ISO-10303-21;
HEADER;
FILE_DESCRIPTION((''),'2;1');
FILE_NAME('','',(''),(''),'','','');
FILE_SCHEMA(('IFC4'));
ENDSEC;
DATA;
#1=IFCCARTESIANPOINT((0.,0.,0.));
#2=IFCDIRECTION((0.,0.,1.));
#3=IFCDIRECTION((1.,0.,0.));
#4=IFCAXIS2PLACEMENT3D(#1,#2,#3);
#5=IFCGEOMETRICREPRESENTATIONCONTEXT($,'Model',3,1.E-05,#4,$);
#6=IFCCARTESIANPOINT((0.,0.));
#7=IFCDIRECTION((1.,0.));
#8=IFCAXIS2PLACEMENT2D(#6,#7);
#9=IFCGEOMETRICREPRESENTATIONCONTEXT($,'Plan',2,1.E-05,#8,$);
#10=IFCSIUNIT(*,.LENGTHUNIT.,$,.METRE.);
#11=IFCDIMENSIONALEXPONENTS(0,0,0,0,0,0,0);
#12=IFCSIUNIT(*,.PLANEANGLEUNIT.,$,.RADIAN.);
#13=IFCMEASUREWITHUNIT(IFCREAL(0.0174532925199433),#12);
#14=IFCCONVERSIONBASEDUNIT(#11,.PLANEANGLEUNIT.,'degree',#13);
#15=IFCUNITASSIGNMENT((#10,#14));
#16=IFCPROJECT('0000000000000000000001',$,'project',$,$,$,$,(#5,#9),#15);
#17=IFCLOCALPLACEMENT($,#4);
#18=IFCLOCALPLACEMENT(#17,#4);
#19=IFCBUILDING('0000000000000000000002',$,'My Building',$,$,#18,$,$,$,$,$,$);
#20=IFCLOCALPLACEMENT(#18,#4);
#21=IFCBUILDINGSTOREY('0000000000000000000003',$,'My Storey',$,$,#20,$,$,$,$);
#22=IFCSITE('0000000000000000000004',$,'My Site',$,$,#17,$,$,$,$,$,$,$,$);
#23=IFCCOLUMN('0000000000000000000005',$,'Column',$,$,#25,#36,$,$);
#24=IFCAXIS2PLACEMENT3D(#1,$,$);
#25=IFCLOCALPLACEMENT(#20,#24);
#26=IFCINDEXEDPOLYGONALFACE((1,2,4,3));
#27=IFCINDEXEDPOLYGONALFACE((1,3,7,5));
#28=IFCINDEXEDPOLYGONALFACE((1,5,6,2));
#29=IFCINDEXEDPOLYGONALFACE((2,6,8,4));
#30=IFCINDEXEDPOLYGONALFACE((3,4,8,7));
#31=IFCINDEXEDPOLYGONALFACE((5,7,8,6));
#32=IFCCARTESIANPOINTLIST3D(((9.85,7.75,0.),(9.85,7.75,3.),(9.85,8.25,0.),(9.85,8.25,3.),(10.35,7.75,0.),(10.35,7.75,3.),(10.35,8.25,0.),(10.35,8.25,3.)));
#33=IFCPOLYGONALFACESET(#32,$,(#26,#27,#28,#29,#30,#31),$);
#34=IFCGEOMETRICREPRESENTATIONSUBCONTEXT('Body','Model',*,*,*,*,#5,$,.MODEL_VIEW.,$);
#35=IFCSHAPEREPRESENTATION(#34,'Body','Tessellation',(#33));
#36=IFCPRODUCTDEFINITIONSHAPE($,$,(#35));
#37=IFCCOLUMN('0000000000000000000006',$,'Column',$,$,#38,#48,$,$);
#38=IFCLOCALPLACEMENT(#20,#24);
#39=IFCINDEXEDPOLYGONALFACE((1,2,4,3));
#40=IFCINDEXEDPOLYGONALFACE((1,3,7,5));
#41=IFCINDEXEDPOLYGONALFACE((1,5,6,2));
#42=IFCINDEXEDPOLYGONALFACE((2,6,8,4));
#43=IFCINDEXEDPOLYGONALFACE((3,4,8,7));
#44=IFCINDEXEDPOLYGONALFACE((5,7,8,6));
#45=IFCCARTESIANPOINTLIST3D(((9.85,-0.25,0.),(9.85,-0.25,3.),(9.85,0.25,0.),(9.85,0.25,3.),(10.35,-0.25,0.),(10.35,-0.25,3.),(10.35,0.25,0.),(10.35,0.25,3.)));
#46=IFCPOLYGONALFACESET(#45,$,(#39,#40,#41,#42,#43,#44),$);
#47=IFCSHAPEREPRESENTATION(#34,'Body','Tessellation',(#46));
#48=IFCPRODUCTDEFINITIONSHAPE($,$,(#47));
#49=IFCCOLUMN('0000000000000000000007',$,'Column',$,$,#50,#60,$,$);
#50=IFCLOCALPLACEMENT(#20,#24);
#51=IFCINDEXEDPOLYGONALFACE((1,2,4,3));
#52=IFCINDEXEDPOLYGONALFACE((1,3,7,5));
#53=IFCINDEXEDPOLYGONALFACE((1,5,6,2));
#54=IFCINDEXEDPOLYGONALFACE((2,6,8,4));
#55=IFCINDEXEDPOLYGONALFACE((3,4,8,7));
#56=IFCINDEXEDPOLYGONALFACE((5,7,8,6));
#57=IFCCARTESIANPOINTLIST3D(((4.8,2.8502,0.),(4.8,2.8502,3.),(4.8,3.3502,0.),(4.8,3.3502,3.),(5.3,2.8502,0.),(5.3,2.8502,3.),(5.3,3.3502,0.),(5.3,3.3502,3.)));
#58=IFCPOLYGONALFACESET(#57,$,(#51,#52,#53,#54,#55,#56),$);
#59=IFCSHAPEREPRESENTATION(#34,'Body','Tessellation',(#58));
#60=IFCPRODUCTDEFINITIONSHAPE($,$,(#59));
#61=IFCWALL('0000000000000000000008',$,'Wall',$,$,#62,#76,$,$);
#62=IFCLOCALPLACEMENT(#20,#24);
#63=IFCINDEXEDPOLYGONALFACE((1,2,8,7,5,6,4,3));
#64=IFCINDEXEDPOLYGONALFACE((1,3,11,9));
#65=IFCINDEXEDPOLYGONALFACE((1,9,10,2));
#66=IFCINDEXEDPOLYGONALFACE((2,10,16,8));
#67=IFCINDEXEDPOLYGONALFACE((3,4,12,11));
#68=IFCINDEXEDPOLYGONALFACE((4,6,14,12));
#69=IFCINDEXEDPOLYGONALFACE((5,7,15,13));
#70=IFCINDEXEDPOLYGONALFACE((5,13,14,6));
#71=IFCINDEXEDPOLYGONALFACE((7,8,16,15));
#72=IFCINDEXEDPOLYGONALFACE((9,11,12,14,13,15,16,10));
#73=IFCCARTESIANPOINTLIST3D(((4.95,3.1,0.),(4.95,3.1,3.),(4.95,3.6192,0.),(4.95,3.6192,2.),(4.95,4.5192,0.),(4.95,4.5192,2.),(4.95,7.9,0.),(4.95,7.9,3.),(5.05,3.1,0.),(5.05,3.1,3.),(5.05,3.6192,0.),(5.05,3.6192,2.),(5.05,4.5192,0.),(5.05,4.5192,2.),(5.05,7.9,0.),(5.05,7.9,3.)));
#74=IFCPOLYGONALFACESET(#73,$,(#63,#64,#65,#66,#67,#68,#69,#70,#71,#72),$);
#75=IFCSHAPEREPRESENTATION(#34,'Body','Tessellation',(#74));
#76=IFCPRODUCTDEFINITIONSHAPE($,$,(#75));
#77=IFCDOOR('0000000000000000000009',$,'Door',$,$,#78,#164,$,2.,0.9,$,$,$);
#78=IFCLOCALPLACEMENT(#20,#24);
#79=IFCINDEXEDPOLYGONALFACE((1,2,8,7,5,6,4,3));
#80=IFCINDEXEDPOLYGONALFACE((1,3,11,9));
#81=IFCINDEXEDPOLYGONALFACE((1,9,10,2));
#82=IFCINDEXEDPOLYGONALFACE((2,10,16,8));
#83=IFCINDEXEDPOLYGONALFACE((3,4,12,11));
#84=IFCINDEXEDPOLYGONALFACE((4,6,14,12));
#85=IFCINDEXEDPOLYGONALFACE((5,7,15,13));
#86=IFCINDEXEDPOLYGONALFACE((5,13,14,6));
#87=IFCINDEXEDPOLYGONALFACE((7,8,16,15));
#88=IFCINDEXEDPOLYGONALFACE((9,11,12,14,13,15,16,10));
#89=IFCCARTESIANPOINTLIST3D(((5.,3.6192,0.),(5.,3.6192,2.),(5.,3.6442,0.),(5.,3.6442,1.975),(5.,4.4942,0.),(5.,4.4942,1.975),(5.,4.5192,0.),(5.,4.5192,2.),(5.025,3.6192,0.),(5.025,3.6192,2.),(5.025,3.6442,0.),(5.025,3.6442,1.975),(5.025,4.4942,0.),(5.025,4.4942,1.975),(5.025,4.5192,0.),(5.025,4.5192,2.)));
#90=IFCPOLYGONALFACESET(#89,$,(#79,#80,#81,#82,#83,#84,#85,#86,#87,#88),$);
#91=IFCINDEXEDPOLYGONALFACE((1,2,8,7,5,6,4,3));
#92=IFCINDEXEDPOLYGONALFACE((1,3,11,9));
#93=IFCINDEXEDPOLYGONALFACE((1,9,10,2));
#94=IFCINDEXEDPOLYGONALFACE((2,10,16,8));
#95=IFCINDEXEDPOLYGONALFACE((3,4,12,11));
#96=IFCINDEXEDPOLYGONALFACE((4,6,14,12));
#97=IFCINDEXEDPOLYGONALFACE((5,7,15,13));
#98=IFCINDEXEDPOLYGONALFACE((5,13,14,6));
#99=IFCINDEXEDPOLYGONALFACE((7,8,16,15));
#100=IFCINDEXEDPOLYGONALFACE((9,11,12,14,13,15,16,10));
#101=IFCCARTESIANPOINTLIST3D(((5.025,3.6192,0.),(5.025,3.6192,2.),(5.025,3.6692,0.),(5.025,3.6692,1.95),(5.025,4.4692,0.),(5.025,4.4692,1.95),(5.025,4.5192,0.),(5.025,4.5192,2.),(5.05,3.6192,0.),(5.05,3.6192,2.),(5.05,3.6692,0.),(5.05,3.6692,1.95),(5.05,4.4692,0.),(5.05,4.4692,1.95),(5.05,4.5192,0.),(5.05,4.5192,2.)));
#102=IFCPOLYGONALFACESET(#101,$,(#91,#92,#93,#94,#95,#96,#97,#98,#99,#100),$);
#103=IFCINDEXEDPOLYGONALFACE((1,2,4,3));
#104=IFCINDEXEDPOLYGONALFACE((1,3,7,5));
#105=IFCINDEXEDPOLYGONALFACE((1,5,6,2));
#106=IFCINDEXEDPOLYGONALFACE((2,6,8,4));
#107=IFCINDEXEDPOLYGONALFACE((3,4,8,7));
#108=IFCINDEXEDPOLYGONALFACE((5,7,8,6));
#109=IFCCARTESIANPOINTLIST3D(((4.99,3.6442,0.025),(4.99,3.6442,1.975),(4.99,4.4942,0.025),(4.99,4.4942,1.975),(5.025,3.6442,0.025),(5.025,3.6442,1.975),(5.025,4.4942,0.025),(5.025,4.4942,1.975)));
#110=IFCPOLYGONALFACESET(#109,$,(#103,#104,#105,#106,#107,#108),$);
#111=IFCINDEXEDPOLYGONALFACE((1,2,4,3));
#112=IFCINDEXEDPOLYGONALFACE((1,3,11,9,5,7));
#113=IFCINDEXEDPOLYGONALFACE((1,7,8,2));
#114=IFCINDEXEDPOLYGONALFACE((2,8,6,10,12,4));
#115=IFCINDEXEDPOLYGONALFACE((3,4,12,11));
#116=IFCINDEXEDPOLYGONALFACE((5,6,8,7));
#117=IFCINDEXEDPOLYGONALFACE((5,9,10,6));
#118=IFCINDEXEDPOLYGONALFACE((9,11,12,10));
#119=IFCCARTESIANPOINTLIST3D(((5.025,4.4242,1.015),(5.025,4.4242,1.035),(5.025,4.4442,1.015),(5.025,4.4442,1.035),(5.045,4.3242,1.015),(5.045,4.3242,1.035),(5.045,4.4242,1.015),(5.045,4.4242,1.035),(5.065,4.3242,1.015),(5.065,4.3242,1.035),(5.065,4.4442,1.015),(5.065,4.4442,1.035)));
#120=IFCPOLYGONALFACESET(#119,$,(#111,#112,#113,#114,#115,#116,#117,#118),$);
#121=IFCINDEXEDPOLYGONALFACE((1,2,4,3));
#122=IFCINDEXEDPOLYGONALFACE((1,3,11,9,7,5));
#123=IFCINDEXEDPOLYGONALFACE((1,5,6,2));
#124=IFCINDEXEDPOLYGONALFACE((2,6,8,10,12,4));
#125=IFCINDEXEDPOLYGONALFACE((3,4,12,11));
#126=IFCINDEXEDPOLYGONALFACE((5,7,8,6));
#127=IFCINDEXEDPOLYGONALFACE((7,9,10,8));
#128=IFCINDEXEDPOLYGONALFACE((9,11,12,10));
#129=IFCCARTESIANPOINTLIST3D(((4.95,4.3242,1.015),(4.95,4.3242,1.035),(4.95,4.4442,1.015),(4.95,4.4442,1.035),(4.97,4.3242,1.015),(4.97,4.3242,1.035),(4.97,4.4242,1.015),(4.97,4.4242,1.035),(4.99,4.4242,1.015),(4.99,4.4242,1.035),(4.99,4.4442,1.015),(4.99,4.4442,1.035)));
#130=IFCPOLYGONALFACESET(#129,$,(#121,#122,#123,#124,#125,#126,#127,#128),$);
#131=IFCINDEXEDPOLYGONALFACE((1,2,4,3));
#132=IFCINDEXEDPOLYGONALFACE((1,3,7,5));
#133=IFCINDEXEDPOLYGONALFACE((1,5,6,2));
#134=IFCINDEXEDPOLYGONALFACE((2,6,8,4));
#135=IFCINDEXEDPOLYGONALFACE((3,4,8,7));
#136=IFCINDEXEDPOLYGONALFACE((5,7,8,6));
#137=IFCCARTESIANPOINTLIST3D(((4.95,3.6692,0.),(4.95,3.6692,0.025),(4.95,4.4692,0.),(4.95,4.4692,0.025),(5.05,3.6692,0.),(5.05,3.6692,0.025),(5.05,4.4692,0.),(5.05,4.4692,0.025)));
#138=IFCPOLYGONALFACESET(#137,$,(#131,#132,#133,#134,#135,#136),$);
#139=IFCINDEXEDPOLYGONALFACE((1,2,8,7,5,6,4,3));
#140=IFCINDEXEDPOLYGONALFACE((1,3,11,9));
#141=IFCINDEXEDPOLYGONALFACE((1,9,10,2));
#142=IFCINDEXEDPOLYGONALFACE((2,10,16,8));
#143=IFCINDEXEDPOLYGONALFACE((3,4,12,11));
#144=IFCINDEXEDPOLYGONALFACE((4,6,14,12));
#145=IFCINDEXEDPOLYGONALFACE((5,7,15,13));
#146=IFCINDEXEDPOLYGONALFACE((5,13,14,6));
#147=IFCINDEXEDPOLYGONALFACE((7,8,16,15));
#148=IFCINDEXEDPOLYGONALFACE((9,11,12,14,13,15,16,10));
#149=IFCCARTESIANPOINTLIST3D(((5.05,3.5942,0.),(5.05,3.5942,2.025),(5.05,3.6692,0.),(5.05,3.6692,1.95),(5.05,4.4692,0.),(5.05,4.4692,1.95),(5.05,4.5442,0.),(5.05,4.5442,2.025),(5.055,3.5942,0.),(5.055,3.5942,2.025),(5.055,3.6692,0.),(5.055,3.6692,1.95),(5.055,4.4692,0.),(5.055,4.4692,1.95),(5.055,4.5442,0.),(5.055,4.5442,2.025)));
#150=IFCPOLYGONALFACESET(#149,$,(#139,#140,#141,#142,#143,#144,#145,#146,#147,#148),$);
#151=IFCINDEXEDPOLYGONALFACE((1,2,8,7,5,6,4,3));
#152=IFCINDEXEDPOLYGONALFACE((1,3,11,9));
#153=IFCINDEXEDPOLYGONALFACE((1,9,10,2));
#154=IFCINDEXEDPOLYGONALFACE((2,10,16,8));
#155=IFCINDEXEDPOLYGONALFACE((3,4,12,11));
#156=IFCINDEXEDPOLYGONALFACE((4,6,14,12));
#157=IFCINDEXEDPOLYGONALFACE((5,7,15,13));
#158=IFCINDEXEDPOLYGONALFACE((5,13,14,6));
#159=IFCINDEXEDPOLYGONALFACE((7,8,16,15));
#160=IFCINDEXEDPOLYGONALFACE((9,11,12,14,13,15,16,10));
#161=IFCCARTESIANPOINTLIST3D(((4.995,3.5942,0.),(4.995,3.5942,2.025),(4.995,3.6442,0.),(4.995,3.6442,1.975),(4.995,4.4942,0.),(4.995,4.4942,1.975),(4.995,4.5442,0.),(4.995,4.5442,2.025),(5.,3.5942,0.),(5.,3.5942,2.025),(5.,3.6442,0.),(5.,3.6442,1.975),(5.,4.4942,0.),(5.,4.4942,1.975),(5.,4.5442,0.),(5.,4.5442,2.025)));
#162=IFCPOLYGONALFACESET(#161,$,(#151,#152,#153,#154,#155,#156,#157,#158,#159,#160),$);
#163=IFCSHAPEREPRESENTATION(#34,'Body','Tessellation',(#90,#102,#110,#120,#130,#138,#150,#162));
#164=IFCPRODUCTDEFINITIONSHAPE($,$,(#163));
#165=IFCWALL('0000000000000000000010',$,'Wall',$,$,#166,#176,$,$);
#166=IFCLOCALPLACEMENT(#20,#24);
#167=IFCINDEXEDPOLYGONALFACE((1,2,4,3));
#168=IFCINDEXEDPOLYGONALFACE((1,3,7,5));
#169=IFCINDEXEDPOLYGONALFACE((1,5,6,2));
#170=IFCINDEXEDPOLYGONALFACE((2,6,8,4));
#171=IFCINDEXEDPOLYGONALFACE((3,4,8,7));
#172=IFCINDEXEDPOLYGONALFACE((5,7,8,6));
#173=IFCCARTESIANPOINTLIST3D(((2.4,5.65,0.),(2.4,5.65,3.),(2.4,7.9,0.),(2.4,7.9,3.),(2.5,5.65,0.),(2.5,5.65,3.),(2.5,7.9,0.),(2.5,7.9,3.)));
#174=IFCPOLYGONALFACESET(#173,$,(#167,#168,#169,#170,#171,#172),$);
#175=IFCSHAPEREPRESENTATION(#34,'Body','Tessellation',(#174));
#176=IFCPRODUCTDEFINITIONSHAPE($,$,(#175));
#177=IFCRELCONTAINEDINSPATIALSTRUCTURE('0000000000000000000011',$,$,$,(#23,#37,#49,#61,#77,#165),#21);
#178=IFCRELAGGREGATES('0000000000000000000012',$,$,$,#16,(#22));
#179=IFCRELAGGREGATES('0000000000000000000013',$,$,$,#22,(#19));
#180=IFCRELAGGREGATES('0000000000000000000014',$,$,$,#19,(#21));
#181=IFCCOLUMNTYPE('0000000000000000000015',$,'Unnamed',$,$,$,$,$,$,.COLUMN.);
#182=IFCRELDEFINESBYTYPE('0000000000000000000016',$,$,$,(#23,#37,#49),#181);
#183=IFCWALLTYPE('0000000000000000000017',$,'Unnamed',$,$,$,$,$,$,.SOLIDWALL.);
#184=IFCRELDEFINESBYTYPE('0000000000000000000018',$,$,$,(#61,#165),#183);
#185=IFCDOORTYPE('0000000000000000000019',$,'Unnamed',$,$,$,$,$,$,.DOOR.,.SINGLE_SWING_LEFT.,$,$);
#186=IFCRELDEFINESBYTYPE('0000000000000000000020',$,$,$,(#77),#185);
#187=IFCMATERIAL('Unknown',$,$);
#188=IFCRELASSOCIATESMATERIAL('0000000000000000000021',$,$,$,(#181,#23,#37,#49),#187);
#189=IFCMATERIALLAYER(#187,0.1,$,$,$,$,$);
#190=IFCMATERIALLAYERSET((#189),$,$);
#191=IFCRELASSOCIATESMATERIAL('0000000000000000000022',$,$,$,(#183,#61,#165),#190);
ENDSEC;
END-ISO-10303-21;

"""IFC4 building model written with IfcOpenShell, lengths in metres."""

from ifc_helpers import new_model, entity, si_unit, converted_unit, frame, origin_with_axes, origin_2d_with_axis, place, context, subcontext, project, spatial, line, indexed_curve, rectangle, outline, extrude, shape, source, transform, mapped, material, layer, layer_set, layer_usage, material_profile, profile_set, profile_usage, type_object, type_shapes, element, fill, save


model = new_model("IFC4")

# Units and contexts
model_context = context("Model", 3, precision=1e-05, world=origin_with_axes())
plan_context = context("Plan", 2, precision=1e-05, world=origin_2d_with_axis())
body_context_1 = subcontext(model_context, "Body", "Model", "MODEL_VIEW")
body_context_2 = subcontext(plan_context, "Body", "Plan", "PLAN_VIEW")
ifc_project = project(units=[si_unit("LENGTHUNIT", "METRE"), converted_unit("PLANEANGLEUNIT", "degree", entity("IfcReal", 0.0174532925199433), si_unit("PLANEANGLEUNIT", "RADIAN"), dimensions=[0, 0, 0, 0, 0, 0, 0])], contexts=[model_context, plan_context])

# Site, building, storey
site_placement = place(None, origin_with_axes())
site = spatial("IfcSite", under=ifc_project, at=site_placement, Name="My Site")
building_placement = place(site_placement, origin_with_axes())
building = spatial("IfcBuilding", under=site, at=building_placement, Name="My Building")
storey_placement = place(building_placement, origin_with_axes())
storey = spatial("IfcBuildingStorey", under=building, at=storey_placement, Name="My Storey")

# Columns
ifc_material = material(Name="Unknown")
ifc_material_profile = material_profile(ifc_material, rectangle(XDim=0.5, YDim=0.5))
ifc_profile_set = profile_set([ifc_material_profile])
ifc_profile_usage_1 = profile_usage(ifc_profile_set, cardinal=5)
column_type = type_object("IfcColumnType", Name="Unnamed", PredefinedType="COLUMN", material=ifc_profile_set)
column_1_placement = place(storey_placement, frame((10.1, 8.0, 0.0), z_axis=(0.0, 0.0, 1.0), x_axis=(1.0, 0.0, 0.0)))
element("IfcColumn", 1, at=column_1_placement, inside=storey, type_object=column_type, material=ifc_profile_usage_1, Name="Column", context=body_context_1, shape_type="SweptSolid", body=[
    extrude(rectangle(XDim=0.5, YDim=0.5), origin_with_axes(), (0.0, 0.0, 1.0), 3.0),
])
ifc_profile_usage_2 = profile_usage(ifc_profile_set, cardinal=5)
column_2_placement = place(storey_placement, frame((10.1, 0.0, 0.0), z_axis=(0.0, 0.0, 1.0), x_axis=(1.0, 0.0, 0.0)))
element("IfcColumn", 2, at=column_2_placement, inside=storey, type_object=column_type, material=ifc_profile_usage_2, Name="Column", context=body_context_1, shape_type="SweptSolid", body=[
    extrude(rectangle(XDim=0.5, YDim=0.5), origin_with_axes(), (0.0, 0.0, 1.0), 3.0),
])
ifc_profile_usage_3 = profile_usage(ifc_profile_set, cardinal=5)
column_3_placement = place(storey_placement, frame((5.05, 3.1002, 0.0), z_axis=(0.0, 0.0, 1.0), x_axis=(1.0, 0.0, 0.0)))
element("IfcColumn", 3, at=column_3_placement, inside=storey, type_object=column_type, material=ifc_profile_usage_3, Name="Column", context=body_context_1, shape_type="SweptSolid", body=[
    extrude(rectangle(XDim=0.5, YDim=0.5), origin_with_axes(), (0.0, 0.0, 1.0), 3.0),
])

# Shared definitions
ifc_layer = layer(ifc_material, 0.1)
ifc_layer_set = layer_set([ifc_layer])
wall_type = type_object("IfcWallType", Name="Unnamed", PredefinedType="SOLIDWALL", material=ifc_layer_set)
shared_shape_1 = source(origin_with_axes(), body_context_1, "Body", "SweptSolid", [
    extrude(outline(indexed_curve([(0.0, 0.0), (0.9, 0.0), (0.9, 2.0), (0.0, 2.0)], segments=[line(1, 2, 3, 4, 1)])), frame((0.0, -0.6, 0.0), z_axis=(0.0, -1.0, 0.0), x_axis=(1.0, 0.0, 0.0)), (0.0, 0.0, -1.0), 1.2),
])
door_type = type_object("IfcDoorType", Name="Unnamed", OperationType="SINGLE_SWING_LEFT", PredefinedType="DOOR")
shared_shape_2 = source(origin_with_axes(), body_context_1, "Body", "SweptSolid", [
    extrude(outline(indexed_curve([(0.0, 0.0), (0.0, 2.0), (0.9, 2.0), (0.9, 0.0), (0.875, 0.0), (0.875, 1.975), (0.025, 1.975), (0.025, 0.0)], segments=[line(1, 2, 3, 4, 5, 6, 7, 8, 1)])), frame((0.0, 0.025, 0.0), z_axis=(0.0, -1.0, 0.0), x_axis=(1.0, 0.0, 0.0)), (0.0, 0.0, -1.0), 0.025),
    extrude(outline(indexed_curve([(0.0, 0.0), (0.0, 2.0), (0.9, 2.0), (0.9, 0.0), (0.85, 0.0), (0.85, 1.95), (0.05, 1.95), (0.05, 0.0)], segments=[line(1, 2, 3, 4, 5, 6, 7, 8, 1)])), frame((0.0, 0.0, 0.0), z_axis=(0.0, -1.0, 0.0), x_axis=(1.0, 0.0, 0.0)), (0.0, 0.0, -1.0), 0.025),
    extrude(outline(indexed_curve([(0.0, 0.0), (0.85, 0.0), (0.85, 0.035), (0.0, 0.035)], segments=[line(1, 2, 3, 4, 1)])), frame((0.025, 0.025, 0.025), z_axis=(0.0, 0.0, 1.0), x_axis=(1.0, 0.0, 0.0)), (0.0, 0.0, 1.0), 1.95),
    extrude(outline(indexed_curve([(0.0, 0.0), (0.0, -0.04), (-0.12, -0.04), (-0.12, -0.02), (-0.02, -0.02), (-0.02, 0.0)], segments=[line(1, 2, 3, 4, 5, 6, 1)])), frame((0.825, 0.025, 1.015), z_axis=(0.0, 0.0, 1.0), x_axis=(1.0, 0.0, 0.0)), (0.0, 0.0, 1.0), 0.02),
    extrude(outline(indexed_curve([(0.0, 0.0), (0.0, 0.04), (-0.12, 0.04), (-0.12, 0.02), (-0.02, 0.02), (-0.02, 0.0)], segments=[line(1, 2, 3, 4, 5, 6, 1)])), frame((0.825, 0.06, 1.015), z_axis=(0.0, 0.0, 1.0), x_axis=(1.0, 0.0, 0.0)), (0.0, 0.0, 1.0), 0.02),
    extrude(outline(indexed_curve([(0.0, 0.0), (0.8, 0.0), (0.8, 0.1), (0.0, 0.1)], segments=[line(1, 2, 3, 4, 1)])), frame((0.05, 0.0, 0.0), z_axis=(0.0, 0.0, 1.0), x_axis=(1.0, 0.0, 0.0)), (0.0, 0.0, 1.0), 0.025),
    extrude(outline(indexed_curve([(0.0, 0.0), (0.0, 2.025), (0.95, 2.025), (0.95, 0.0), (0.875, 0.0), (0.875, 1.95), (0.075, 1.95), (0.075, 0.0)], segments=[line(1, 2, 3, 4, 5, 6, 7, 8, 1)])), frame((-0.025, -0.005, 0.0), z_axis=(0.0, -1.0, 0.0), x_axis=(1.0, 0.0, 0.0)), (0.0, 0.0, -1.0), 0.005),
    extrude(outline(indexed_curve([(0.0, 0.0), (0.0, 2.025), (0.95, 2.025), (0.95, 0.0), (0.9, 0.0), (0.9, 1.975), (0.05, 1.975), (0.05, 0.0)], segments=[line(1, 2, 3, 4, 5, 6, 7, 8, 1)])), frame((-0.025, 0.05, 0.0), z_axis=(0.0, -1.0, 0.0), x_axis=(1.0, 0.0, 0.0)), (0.0, 0.0, -1.0), 0.005),
])
shared_shape_3 = source(origin_with_axes(), body_context_2, "Body", "Curve2D", [
    entity("IfcIndexedPolyCurve", entity("IfcCartesianPointList2D", [[0.0, 0.0], [0.0, 0.05], [0.025, 0.05], [0.025, 0.025], [0.05, 0.025], [0.05, 0.0]]), [entity("IfcLineIndex", [1, 2, 3, 4, 5, 6, 1])]),
    entity("IfcIndexedPolyCurve", entity("IfcCartesianPointList2D", [[0.9, 0.0], [0.9, 0.05], [0.875, 0.05], [0.875, 0.025], [0.85, 0.025], [0.85, 0.0]]), [entity("IfcLineIndex", [1, 2, 3, 4, 5, 6, 1])]),
    entity("IfcTrimmedCurve", entity("IfcEllipse", entity("IfcAxis2Placement2D", entity("IfcCartesianPoint", [0.06, 0.05]), entity("IfcDirection", [1.0, 0.0])), 0.815, 0.85), [entity("IfcCartesianPoint", [0.875, 0.05])], [entity("IfcCartesianPoint", [0.06, 0.9])], True, "CARTESIAN"),
    entity("IfcIndexedPolyCurve", entity("IfcCartesianPointList2D", [[0.025, 0.05], [0.06, 0.05], [0.06, 0.9], [0.025, 0.9]]), [entity("IfcLineIndex", [1, 2, 3, 4, 1])]),
])
type_shapes(door_type, [shared_shape_2, shared_shape_3])

# Wall, opening, door
ifc_layer_usage_1 = layer_usage(ifc_layer_set, "AXIS2", "POSITIVE", 0.0)
wall_1_placement = place(storey_placement, frame((5.05, 3.1, 0.0), z_axis=(0.0, 0.0, 1.0), x_axis=(0.0, 1.0, 0.0)))
wall_1 = element("IfcWall", 4, at=wall_1_placement, inside=storey, type_object=wall_type, material=ifc_layer_usage_1, Name="Wall", context=body_context_1, shape_type="SweptSolid", body=[
    extrude(outline(indexed_curve([(0.0, 0.0), (0.0, 0.1), (4.8, 0.1), (4.8, 0.0)], segments=[line(1, 2, 3, 4, 1)])), origin_with_axes(), (0.0, 0.0, 1.0), 3.0),
])
opening_1_placement = place(wall_1_placement, frame((0.5192, 0.0, 0.0), z_axis=(0.0, 0.0, 1.0), x_axis=(1.0, 0.0, 0.0)))
opening_1 = element("IfcOpeningElement", 5, at=opening_1_placement, cuts=wall_1, PredefinedType="OPENING", context=body_context_1, shape_type="MappedRepresentation", body=[
    mapped(shared_shape_1, transform((0.0, 0.0, 0.0), x_axis=(1.0, 0.0, 0.0), y_axis=(0.0, 1.0, 0.0), z_axis=(0.0, 0.0, 1.0), scale=1.0)),
])
door_1_placement = place(opening_1_placement, origin_with_axes())
door_1 = element("IfcDoor", 6, at=door_1_placement, inside=storey, type_object=door_type, Name="Door", OverallHeight=2.0, OverallWidth=0.9, shapes=[
    shape(body_context_1, "Body", "MappedRepresentation", [mapped(shared_shape_2, transform((0.0, 0.0, 0.0), x_axis=(1.0, 0.0, 0.0), y_axis=(0.0, 1.0, 0.0), z_axis=(0.0, 0.0, 1.0), scale=1.0))]),
    shape(body_context_2, "Body", "MappedRepresentation", [mapped(shared_shape_3, transform((0.0, 0.0, 0.0), x_axis=(1.0, 0.0, 0.0), y_axis=(0.0, 1.0, 0.0), z_axis=(0.0, 0.0, 1.0), scale=1.0))]),
])
fill(opening_1, door_1)

# Wall
ifc_layer_usage_2 = layer_usage(ifc_layer_set, "AXIS2", "POSITIVE", 0.0)
wall_2_placement = place(storey_placement, frame((2.5, 5.65, 0.0), z_axis=(0.0, 0.0, 1.0), x_axis=(0.0, 1.0, 0.0)))
element("IfcWall", 7, at=wall_2_placement, inside=storey, type_object=wall_type, material=ifc_layer_usage_2, Name="Wall", context=body_context_1, shape_type="SweptSolid", body=[
    extrude(outline(indexed_curve([(0.0, 0.0), (0.0, 0.1), (2.25, 0.1), (2.25, 0.0)], segments=[line(1, 2, 3, 4, 1)])), origin_with_axes(), (0.0, 0.0, 1.0), 3.0),
])

save(model, "model.ifc")
